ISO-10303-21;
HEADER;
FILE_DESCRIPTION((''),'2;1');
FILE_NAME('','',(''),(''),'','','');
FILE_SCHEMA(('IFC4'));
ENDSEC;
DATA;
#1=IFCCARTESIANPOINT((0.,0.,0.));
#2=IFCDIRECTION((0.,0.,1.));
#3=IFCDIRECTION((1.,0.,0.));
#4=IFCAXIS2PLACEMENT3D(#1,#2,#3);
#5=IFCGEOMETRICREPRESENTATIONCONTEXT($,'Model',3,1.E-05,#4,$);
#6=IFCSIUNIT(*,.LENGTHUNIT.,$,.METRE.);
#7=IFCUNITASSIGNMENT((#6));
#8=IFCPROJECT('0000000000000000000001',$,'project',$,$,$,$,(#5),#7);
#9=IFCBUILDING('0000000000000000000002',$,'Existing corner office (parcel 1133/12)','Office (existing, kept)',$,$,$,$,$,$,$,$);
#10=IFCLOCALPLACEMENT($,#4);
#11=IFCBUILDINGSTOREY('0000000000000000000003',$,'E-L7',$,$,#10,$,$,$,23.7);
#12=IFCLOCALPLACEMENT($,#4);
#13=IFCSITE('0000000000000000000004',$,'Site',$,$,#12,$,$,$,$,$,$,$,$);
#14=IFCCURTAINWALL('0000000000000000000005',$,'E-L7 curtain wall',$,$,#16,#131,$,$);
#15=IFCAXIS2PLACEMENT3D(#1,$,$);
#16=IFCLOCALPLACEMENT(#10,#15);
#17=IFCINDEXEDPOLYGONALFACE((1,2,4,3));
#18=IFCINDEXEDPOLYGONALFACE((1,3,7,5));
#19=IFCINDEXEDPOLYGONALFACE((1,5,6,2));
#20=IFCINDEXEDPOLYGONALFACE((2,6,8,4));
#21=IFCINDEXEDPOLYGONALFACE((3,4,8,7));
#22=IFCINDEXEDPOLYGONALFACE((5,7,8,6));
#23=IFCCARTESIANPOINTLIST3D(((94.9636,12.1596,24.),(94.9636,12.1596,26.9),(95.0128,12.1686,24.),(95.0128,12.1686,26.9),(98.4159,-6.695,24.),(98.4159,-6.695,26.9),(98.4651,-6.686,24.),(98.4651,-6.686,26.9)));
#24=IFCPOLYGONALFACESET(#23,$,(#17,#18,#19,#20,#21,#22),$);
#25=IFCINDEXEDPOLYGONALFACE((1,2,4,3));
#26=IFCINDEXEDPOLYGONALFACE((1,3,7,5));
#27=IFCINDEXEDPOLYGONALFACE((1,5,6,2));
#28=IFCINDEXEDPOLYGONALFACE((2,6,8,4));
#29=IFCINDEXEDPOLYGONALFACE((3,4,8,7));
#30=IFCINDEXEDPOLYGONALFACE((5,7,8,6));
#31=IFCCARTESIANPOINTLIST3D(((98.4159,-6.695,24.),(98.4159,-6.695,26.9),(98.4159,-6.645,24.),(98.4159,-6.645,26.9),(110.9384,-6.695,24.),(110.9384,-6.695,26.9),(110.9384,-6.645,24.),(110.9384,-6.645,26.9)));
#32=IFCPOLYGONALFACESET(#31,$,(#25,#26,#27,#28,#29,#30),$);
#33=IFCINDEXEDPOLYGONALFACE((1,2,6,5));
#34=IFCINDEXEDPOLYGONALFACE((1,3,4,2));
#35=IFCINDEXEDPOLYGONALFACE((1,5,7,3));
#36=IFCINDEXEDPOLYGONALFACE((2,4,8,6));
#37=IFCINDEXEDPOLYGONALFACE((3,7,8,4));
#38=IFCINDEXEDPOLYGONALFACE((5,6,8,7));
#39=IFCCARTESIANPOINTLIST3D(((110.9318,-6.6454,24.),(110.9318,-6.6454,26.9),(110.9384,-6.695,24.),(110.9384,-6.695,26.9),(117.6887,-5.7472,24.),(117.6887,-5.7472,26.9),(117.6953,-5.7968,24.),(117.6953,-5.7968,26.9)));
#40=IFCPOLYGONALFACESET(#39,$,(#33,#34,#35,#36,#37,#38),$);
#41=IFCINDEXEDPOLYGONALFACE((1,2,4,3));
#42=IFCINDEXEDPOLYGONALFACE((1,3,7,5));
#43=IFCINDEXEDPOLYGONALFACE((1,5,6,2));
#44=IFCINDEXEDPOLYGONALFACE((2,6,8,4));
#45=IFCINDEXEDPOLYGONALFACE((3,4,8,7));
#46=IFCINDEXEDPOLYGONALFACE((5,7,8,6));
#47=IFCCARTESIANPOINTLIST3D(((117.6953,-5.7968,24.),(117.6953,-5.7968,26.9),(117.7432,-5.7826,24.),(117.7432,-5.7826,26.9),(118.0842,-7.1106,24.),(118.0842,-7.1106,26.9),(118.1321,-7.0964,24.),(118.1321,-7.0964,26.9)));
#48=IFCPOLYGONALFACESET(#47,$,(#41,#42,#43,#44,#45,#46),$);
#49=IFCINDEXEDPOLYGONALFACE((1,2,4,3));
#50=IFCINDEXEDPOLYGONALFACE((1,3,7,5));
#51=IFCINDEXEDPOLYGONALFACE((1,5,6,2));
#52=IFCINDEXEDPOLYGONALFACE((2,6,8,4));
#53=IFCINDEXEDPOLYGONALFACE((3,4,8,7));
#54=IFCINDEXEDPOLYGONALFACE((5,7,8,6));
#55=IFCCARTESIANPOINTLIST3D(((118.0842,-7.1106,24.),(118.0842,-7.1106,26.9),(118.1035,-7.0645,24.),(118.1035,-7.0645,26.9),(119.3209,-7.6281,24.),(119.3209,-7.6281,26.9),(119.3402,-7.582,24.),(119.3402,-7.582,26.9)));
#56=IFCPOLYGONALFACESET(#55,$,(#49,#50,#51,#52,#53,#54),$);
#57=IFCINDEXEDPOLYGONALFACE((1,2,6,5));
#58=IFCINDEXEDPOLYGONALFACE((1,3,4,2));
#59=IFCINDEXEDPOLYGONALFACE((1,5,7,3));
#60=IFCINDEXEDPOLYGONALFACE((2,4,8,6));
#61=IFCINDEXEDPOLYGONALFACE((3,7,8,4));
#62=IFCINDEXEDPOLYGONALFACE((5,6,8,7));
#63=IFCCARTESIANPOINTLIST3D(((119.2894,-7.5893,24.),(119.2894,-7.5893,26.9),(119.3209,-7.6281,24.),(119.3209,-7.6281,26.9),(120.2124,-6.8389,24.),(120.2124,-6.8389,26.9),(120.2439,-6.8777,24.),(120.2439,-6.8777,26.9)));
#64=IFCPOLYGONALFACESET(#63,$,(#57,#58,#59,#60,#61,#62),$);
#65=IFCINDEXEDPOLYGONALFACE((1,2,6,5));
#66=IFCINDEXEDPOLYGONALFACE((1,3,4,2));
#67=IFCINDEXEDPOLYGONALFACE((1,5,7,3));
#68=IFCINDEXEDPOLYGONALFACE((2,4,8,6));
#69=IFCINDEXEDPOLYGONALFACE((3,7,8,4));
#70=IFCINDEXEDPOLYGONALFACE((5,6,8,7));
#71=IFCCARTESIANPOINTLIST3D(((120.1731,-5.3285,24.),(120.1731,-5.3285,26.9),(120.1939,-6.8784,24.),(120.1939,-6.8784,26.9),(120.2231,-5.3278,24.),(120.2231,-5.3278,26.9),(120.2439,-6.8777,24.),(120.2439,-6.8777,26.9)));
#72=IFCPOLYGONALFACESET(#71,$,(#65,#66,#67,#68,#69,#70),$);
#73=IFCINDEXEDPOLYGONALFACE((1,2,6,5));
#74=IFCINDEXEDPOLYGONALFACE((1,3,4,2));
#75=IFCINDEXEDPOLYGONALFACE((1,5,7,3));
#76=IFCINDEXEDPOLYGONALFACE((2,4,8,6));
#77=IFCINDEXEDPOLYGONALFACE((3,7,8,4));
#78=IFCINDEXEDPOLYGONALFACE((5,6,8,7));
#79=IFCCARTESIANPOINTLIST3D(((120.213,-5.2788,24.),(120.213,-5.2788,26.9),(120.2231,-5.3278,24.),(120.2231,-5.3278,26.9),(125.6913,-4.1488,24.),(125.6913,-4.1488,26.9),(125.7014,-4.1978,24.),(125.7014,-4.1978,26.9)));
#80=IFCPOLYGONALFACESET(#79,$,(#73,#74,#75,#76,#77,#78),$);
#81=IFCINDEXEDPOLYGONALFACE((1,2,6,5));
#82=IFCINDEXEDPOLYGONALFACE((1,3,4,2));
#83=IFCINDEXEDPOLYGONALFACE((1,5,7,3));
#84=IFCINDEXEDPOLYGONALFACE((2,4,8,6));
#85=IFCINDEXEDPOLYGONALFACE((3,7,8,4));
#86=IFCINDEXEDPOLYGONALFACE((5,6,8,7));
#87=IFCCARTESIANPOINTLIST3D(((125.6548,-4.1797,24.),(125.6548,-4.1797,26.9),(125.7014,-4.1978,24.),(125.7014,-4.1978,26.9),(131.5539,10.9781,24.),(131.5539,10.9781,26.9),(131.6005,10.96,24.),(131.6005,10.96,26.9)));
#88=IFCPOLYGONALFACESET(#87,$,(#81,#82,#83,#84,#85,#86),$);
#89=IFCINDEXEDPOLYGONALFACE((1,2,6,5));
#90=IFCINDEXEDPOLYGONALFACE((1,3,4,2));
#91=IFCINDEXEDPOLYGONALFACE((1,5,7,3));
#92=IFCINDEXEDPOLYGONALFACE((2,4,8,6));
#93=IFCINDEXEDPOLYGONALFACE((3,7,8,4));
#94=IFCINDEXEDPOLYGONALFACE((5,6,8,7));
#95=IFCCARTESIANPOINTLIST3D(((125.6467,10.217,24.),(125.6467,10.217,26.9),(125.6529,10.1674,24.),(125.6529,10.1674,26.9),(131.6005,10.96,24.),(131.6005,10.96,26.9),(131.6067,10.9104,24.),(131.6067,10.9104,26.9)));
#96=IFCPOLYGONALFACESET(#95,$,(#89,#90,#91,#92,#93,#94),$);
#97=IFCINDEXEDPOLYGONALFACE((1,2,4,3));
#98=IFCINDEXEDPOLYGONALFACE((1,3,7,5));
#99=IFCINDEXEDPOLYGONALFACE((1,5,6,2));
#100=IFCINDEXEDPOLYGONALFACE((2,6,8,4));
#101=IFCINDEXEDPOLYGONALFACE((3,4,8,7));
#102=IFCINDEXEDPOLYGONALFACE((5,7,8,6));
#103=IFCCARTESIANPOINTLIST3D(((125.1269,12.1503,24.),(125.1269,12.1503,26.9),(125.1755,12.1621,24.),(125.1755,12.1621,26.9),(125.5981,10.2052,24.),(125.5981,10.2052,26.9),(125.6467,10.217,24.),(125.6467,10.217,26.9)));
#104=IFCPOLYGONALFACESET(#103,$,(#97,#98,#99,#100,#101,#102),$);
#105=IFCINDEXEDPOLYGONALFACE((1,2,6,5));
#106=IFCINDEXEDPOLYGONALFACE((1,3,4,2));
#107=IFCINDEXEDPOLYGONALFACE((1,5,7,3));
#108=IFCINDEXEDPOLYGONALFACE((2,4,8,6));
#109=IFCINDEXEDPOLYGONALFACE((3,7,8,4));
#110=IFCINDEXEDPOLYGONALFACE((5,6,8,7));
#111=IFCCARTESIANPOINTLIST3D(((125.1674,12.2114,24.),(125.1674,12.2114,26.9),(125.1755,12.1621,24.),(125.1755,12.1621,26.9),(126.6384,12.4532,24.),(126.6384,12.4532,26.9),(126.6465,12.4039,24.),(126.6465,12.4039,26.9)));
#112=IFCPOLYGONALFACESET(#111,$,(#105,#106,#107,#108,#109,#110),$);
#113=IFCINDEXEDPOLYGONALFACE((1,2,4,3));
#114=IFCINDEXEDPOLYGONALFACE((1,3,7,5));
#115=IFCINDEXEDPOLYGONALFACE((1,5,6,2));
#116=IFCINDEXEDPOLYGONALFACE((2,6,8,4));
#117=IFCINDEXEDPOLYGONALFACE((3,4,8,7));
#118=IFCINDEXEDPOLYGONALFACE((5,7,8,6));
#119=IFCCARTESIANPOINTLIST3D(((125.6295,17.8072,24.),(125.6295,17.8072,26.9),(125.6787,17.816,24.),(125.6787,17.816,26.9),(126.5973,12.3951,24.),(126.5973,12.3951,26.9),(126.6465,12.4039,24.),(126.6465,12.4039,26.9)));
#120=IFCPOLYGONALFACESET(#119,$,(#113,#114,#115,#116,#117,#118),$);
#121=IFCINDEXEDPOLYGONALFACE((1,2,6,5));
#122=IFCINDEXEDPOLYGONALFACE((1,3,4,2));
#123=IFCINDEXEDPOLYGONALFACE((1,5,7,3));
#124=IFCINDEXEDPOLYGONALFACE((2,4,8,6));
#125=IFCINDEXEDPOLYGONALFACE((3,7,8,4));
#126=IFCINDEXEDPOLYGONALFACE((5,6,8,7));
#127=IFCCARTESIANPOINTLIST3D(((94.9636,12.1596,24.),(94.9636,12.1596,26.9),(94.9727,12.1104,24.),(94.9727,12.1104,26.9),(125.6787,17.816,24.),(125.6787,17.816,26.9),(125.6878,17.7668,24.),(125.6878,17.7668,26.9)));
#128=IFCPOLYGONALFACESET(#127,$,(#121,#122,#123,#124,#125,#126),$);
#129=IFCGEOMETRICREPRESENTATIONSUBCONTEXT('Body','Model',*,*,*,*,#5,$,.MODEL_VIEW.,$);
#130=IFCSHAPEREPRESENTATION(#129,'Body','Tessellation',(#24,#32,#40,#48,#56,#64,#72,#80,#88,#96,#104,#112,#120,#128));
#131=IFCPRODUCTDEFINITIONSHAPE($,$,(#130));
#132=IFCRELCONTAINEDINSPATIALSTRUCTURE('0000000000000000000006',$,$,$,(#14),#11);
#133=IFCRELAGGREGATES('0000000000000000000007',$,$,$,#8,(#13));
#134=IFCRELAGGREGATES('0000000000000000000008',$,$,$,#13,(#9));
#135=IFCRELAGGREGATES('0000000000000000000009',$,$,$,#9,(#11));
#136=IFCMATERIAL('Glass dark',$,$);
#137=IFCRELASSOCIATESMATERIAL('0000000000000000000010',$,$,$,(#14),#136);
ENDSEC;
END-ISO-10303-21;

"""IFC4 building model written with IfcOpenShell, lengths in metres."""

from ifc_helpers import new_model, si_unit, frame, origin_with_axes, place, context, subcontext, project, spatial, polyline, outline, extrude, material, element, save


model = new_model("IFC4")

# Units and contexts
model_context = context("Model", 3, precision=1e-05, world=origin_with_axes())
body_context = subcontext(model_context, "Body", "Model", "MODEL_VIEW")
ifc_project = project(units=[si_unit("LENGTHUNIT", "METRE")], contexts=[model_context])

# Site, building, storey
site_placement = place(None, origin_with_axes())
site = spatial("IfcSite", under=ifc_project, at=site_placement, Name="Site")
building = spatial("IfcBuilding", under=site, Name="Existing corner office (parcel 1133/12)", Description="Office (existing, kept)")
storey_placement = place(None, origin_with_axes())
storey = spatial("IfcBuildingStorey", under=building, at=storey_placement, Name="E-L7", Elevation=23.7)

# Curtain wall
ifc_material_1 = material(Name="Glass dark")
curtain_wall_placement = place(storey_placement, origin_with_axes())
element("IfcCurtainWall", 1, at=curtain_wall_placement, inside=storey, material=ifc_material_1, Name="E-L7 curtain wall", context=body_context, shape_type="SweptSolid", body=[
    extrude(outline(polyline([(94.9636, 12.1596), (98.4159, -6.695), (98.4651, -6.686), (95.0128, 12.1686), (94.9636, 12.1596)])), frame((0.0, 0.0, 24.0), z_axis=(0.0, 0.0, 1.0), x_axis=(1.0, 0.0, 0.0)), (0.0, 0.0, 1.0), 2.9),
    extrude(outline(polyline([(98.4159, -6.695), (110.9384, -6.695), (110.9384, -6.645), (98.4159, -6.645), (98.4159, -6.695)])), frame((0.0, 0.0, 24.0), z_axis=(0.0, 0.0, 1.0), x_axis=(1.0, 0.0, 0.0)), (0.0, 0.0, 1.0), 2.9),
    extrude(outline(polyline([(110.9384, -6.695), (117.6953, -5.7968), (117.6887, -5.7472), (110.9318, -6.6454), (110.9384, -6.695)])), frame((0.0, 0.0, 24.0), z_axis=(0.0, 0.0, 1.0), x_axis=(1.0, 0.0, 0.0)), (0.0, 0.0, 1.0), 2.9),
    extrude(outline(polyline([(117.6953, -5.7968), (118.0842, -7.1106), (118.1321, -7.0964), (117.7432, -5.7826), (117.6953, -5.7968)])), frame((0.0, 0.0, 24.0), z_axis=(0.0, 0.0, 1.0), x_axis=(1.0, 0.0, 0.0)), (0.0, 0.0, 1.0), 2.9),
    extrude(outline(polyline([(118.0842, -7.1106), (119.3209, -7.6281), (119.3402, -7.582), (118.1035, -7.0645), (118.0842, -7.1106)])), frame((0.0, 0.0, 24.0), z_axis=(0.0, 0.0, 1.0), x_axis=(1.0, 0.0, 0.0)), (0.0, 0.0, 1.0), 2.9),
    extrude(outline(polyline([(119.3209, -7.6281), (120.2439, -6.8777), (120.2124, -6.8389), (119.2894, -7.5893), (119.3209, -7.6281)])), frame((0.0, 0.0, 24.0), z_axis=(0.0, 0.0, 1.0), x_axis=(1.0, 0.0, 0.0)), (0.0, 0.0, 1.0), 2.9),
    extrude(outline(polyline([(120.2439, -6.8777), (120.2231, -5.3278), (120.1731, -5.3285), (120.1939, -6.8784), (120.2439, -6.8777)])), frame((0.0, 0.0, 24.0), z_axis=(0.0, 0.0, 1.0), x_axis=(1.0, 0.0, 0.0)), (0.0, 0.0, 1.0), 2.9),
    extrude(outline(polyline([(120.2231, -5.3278), (125.7014, -4.1978), (125.6913, -4.1488), (120.213, -5.2788), (120.2231, -5.3278)])), frame((0.0, 0.0, 24.0), z_axis=(0.0, 0.0, 1.0), x_axis=(1.0, 0.0, 0.0)), (0.0, 0.0, 1.0), 2.9),
    extrude(outline(polyline([(125.7014, -4.1978), (131.6005, 10.96), (131.5539, 10.9781), (125.6548, -4.1797), (125.7014, -4.1978)])), frame((0.0, 0.0, 24.0), z_axis=(0.0, 0.0, 1.0), x_axis=(1.0, 0.0, 0.0)), (0.0, 0.0, 1.0), 2.9),
    extrude(outline(polyline([(131.6005, 10.96), (125.6467, 10.217), (125.6529, 10.1674), (131.6067, 10.9104), (131.6005, 10.96)])), frame((0.0, 0.0, 24.0), z_axis=(0.0, 0.0, 1.0), x_axis=(1.0, 0.0, 0.0)), (0.0, 0.0, 1.0), 2.9),
    extrude(outline(polyline([(125.6467, 10.217), (125.1755, 12.1621), (125.1269, 12.1503), (125.5981, 10.2052), (125.6467, 10.217)])), frame((0.0, 0.0, 24.0), z_axis=(0.0, 0.0, 1.0), x_axis=(1.0, 0.0, 0.0)), (0.0, 0.0, 1.0), 2.9),
    extrude(outline(polyline([(125.1755, 12.1621), (126.6465, 12.4039), (126.6384, 12.4532), (125.1674, 12.2114), (125.1755, 12.1621)])), frame((0.0, 0.0, 24.0), z_axis=(0.0, 0.0, 1.0), x_axis=(1.0, 0.0, 0.0)), (0.0, 0.0, 1.0), 2.9),
    extrude(outline(polyline([(126.6465, 12.4039), (125.6787, 17.816), (125.6295, 17.8072), (126.5973, 12.3951), (126.6465, 12.4039)])), frame((0.0, 0.0, 24.0), z_axis=(0.0, 0.0, 1.0), x_axis=(1.0, 0.0, 0.0)), (0.0, 0.0, 1.0), 2.9),
    extrude(outline(polyline([(125.6787, 17.816), (94.9636, 12.1596), (94.9727, 12.1104), (125.6878, 17.7668), (125.6787, 17.816)])), frame((0.0, 0.0, 24.0), z_axis=(0.0, 0.0, 1.0), x_axis=(1.0, 0.0, 0.0)), (0.0, 0.0, 1.0), 2.9),
])

save(model, "model.ifc")
